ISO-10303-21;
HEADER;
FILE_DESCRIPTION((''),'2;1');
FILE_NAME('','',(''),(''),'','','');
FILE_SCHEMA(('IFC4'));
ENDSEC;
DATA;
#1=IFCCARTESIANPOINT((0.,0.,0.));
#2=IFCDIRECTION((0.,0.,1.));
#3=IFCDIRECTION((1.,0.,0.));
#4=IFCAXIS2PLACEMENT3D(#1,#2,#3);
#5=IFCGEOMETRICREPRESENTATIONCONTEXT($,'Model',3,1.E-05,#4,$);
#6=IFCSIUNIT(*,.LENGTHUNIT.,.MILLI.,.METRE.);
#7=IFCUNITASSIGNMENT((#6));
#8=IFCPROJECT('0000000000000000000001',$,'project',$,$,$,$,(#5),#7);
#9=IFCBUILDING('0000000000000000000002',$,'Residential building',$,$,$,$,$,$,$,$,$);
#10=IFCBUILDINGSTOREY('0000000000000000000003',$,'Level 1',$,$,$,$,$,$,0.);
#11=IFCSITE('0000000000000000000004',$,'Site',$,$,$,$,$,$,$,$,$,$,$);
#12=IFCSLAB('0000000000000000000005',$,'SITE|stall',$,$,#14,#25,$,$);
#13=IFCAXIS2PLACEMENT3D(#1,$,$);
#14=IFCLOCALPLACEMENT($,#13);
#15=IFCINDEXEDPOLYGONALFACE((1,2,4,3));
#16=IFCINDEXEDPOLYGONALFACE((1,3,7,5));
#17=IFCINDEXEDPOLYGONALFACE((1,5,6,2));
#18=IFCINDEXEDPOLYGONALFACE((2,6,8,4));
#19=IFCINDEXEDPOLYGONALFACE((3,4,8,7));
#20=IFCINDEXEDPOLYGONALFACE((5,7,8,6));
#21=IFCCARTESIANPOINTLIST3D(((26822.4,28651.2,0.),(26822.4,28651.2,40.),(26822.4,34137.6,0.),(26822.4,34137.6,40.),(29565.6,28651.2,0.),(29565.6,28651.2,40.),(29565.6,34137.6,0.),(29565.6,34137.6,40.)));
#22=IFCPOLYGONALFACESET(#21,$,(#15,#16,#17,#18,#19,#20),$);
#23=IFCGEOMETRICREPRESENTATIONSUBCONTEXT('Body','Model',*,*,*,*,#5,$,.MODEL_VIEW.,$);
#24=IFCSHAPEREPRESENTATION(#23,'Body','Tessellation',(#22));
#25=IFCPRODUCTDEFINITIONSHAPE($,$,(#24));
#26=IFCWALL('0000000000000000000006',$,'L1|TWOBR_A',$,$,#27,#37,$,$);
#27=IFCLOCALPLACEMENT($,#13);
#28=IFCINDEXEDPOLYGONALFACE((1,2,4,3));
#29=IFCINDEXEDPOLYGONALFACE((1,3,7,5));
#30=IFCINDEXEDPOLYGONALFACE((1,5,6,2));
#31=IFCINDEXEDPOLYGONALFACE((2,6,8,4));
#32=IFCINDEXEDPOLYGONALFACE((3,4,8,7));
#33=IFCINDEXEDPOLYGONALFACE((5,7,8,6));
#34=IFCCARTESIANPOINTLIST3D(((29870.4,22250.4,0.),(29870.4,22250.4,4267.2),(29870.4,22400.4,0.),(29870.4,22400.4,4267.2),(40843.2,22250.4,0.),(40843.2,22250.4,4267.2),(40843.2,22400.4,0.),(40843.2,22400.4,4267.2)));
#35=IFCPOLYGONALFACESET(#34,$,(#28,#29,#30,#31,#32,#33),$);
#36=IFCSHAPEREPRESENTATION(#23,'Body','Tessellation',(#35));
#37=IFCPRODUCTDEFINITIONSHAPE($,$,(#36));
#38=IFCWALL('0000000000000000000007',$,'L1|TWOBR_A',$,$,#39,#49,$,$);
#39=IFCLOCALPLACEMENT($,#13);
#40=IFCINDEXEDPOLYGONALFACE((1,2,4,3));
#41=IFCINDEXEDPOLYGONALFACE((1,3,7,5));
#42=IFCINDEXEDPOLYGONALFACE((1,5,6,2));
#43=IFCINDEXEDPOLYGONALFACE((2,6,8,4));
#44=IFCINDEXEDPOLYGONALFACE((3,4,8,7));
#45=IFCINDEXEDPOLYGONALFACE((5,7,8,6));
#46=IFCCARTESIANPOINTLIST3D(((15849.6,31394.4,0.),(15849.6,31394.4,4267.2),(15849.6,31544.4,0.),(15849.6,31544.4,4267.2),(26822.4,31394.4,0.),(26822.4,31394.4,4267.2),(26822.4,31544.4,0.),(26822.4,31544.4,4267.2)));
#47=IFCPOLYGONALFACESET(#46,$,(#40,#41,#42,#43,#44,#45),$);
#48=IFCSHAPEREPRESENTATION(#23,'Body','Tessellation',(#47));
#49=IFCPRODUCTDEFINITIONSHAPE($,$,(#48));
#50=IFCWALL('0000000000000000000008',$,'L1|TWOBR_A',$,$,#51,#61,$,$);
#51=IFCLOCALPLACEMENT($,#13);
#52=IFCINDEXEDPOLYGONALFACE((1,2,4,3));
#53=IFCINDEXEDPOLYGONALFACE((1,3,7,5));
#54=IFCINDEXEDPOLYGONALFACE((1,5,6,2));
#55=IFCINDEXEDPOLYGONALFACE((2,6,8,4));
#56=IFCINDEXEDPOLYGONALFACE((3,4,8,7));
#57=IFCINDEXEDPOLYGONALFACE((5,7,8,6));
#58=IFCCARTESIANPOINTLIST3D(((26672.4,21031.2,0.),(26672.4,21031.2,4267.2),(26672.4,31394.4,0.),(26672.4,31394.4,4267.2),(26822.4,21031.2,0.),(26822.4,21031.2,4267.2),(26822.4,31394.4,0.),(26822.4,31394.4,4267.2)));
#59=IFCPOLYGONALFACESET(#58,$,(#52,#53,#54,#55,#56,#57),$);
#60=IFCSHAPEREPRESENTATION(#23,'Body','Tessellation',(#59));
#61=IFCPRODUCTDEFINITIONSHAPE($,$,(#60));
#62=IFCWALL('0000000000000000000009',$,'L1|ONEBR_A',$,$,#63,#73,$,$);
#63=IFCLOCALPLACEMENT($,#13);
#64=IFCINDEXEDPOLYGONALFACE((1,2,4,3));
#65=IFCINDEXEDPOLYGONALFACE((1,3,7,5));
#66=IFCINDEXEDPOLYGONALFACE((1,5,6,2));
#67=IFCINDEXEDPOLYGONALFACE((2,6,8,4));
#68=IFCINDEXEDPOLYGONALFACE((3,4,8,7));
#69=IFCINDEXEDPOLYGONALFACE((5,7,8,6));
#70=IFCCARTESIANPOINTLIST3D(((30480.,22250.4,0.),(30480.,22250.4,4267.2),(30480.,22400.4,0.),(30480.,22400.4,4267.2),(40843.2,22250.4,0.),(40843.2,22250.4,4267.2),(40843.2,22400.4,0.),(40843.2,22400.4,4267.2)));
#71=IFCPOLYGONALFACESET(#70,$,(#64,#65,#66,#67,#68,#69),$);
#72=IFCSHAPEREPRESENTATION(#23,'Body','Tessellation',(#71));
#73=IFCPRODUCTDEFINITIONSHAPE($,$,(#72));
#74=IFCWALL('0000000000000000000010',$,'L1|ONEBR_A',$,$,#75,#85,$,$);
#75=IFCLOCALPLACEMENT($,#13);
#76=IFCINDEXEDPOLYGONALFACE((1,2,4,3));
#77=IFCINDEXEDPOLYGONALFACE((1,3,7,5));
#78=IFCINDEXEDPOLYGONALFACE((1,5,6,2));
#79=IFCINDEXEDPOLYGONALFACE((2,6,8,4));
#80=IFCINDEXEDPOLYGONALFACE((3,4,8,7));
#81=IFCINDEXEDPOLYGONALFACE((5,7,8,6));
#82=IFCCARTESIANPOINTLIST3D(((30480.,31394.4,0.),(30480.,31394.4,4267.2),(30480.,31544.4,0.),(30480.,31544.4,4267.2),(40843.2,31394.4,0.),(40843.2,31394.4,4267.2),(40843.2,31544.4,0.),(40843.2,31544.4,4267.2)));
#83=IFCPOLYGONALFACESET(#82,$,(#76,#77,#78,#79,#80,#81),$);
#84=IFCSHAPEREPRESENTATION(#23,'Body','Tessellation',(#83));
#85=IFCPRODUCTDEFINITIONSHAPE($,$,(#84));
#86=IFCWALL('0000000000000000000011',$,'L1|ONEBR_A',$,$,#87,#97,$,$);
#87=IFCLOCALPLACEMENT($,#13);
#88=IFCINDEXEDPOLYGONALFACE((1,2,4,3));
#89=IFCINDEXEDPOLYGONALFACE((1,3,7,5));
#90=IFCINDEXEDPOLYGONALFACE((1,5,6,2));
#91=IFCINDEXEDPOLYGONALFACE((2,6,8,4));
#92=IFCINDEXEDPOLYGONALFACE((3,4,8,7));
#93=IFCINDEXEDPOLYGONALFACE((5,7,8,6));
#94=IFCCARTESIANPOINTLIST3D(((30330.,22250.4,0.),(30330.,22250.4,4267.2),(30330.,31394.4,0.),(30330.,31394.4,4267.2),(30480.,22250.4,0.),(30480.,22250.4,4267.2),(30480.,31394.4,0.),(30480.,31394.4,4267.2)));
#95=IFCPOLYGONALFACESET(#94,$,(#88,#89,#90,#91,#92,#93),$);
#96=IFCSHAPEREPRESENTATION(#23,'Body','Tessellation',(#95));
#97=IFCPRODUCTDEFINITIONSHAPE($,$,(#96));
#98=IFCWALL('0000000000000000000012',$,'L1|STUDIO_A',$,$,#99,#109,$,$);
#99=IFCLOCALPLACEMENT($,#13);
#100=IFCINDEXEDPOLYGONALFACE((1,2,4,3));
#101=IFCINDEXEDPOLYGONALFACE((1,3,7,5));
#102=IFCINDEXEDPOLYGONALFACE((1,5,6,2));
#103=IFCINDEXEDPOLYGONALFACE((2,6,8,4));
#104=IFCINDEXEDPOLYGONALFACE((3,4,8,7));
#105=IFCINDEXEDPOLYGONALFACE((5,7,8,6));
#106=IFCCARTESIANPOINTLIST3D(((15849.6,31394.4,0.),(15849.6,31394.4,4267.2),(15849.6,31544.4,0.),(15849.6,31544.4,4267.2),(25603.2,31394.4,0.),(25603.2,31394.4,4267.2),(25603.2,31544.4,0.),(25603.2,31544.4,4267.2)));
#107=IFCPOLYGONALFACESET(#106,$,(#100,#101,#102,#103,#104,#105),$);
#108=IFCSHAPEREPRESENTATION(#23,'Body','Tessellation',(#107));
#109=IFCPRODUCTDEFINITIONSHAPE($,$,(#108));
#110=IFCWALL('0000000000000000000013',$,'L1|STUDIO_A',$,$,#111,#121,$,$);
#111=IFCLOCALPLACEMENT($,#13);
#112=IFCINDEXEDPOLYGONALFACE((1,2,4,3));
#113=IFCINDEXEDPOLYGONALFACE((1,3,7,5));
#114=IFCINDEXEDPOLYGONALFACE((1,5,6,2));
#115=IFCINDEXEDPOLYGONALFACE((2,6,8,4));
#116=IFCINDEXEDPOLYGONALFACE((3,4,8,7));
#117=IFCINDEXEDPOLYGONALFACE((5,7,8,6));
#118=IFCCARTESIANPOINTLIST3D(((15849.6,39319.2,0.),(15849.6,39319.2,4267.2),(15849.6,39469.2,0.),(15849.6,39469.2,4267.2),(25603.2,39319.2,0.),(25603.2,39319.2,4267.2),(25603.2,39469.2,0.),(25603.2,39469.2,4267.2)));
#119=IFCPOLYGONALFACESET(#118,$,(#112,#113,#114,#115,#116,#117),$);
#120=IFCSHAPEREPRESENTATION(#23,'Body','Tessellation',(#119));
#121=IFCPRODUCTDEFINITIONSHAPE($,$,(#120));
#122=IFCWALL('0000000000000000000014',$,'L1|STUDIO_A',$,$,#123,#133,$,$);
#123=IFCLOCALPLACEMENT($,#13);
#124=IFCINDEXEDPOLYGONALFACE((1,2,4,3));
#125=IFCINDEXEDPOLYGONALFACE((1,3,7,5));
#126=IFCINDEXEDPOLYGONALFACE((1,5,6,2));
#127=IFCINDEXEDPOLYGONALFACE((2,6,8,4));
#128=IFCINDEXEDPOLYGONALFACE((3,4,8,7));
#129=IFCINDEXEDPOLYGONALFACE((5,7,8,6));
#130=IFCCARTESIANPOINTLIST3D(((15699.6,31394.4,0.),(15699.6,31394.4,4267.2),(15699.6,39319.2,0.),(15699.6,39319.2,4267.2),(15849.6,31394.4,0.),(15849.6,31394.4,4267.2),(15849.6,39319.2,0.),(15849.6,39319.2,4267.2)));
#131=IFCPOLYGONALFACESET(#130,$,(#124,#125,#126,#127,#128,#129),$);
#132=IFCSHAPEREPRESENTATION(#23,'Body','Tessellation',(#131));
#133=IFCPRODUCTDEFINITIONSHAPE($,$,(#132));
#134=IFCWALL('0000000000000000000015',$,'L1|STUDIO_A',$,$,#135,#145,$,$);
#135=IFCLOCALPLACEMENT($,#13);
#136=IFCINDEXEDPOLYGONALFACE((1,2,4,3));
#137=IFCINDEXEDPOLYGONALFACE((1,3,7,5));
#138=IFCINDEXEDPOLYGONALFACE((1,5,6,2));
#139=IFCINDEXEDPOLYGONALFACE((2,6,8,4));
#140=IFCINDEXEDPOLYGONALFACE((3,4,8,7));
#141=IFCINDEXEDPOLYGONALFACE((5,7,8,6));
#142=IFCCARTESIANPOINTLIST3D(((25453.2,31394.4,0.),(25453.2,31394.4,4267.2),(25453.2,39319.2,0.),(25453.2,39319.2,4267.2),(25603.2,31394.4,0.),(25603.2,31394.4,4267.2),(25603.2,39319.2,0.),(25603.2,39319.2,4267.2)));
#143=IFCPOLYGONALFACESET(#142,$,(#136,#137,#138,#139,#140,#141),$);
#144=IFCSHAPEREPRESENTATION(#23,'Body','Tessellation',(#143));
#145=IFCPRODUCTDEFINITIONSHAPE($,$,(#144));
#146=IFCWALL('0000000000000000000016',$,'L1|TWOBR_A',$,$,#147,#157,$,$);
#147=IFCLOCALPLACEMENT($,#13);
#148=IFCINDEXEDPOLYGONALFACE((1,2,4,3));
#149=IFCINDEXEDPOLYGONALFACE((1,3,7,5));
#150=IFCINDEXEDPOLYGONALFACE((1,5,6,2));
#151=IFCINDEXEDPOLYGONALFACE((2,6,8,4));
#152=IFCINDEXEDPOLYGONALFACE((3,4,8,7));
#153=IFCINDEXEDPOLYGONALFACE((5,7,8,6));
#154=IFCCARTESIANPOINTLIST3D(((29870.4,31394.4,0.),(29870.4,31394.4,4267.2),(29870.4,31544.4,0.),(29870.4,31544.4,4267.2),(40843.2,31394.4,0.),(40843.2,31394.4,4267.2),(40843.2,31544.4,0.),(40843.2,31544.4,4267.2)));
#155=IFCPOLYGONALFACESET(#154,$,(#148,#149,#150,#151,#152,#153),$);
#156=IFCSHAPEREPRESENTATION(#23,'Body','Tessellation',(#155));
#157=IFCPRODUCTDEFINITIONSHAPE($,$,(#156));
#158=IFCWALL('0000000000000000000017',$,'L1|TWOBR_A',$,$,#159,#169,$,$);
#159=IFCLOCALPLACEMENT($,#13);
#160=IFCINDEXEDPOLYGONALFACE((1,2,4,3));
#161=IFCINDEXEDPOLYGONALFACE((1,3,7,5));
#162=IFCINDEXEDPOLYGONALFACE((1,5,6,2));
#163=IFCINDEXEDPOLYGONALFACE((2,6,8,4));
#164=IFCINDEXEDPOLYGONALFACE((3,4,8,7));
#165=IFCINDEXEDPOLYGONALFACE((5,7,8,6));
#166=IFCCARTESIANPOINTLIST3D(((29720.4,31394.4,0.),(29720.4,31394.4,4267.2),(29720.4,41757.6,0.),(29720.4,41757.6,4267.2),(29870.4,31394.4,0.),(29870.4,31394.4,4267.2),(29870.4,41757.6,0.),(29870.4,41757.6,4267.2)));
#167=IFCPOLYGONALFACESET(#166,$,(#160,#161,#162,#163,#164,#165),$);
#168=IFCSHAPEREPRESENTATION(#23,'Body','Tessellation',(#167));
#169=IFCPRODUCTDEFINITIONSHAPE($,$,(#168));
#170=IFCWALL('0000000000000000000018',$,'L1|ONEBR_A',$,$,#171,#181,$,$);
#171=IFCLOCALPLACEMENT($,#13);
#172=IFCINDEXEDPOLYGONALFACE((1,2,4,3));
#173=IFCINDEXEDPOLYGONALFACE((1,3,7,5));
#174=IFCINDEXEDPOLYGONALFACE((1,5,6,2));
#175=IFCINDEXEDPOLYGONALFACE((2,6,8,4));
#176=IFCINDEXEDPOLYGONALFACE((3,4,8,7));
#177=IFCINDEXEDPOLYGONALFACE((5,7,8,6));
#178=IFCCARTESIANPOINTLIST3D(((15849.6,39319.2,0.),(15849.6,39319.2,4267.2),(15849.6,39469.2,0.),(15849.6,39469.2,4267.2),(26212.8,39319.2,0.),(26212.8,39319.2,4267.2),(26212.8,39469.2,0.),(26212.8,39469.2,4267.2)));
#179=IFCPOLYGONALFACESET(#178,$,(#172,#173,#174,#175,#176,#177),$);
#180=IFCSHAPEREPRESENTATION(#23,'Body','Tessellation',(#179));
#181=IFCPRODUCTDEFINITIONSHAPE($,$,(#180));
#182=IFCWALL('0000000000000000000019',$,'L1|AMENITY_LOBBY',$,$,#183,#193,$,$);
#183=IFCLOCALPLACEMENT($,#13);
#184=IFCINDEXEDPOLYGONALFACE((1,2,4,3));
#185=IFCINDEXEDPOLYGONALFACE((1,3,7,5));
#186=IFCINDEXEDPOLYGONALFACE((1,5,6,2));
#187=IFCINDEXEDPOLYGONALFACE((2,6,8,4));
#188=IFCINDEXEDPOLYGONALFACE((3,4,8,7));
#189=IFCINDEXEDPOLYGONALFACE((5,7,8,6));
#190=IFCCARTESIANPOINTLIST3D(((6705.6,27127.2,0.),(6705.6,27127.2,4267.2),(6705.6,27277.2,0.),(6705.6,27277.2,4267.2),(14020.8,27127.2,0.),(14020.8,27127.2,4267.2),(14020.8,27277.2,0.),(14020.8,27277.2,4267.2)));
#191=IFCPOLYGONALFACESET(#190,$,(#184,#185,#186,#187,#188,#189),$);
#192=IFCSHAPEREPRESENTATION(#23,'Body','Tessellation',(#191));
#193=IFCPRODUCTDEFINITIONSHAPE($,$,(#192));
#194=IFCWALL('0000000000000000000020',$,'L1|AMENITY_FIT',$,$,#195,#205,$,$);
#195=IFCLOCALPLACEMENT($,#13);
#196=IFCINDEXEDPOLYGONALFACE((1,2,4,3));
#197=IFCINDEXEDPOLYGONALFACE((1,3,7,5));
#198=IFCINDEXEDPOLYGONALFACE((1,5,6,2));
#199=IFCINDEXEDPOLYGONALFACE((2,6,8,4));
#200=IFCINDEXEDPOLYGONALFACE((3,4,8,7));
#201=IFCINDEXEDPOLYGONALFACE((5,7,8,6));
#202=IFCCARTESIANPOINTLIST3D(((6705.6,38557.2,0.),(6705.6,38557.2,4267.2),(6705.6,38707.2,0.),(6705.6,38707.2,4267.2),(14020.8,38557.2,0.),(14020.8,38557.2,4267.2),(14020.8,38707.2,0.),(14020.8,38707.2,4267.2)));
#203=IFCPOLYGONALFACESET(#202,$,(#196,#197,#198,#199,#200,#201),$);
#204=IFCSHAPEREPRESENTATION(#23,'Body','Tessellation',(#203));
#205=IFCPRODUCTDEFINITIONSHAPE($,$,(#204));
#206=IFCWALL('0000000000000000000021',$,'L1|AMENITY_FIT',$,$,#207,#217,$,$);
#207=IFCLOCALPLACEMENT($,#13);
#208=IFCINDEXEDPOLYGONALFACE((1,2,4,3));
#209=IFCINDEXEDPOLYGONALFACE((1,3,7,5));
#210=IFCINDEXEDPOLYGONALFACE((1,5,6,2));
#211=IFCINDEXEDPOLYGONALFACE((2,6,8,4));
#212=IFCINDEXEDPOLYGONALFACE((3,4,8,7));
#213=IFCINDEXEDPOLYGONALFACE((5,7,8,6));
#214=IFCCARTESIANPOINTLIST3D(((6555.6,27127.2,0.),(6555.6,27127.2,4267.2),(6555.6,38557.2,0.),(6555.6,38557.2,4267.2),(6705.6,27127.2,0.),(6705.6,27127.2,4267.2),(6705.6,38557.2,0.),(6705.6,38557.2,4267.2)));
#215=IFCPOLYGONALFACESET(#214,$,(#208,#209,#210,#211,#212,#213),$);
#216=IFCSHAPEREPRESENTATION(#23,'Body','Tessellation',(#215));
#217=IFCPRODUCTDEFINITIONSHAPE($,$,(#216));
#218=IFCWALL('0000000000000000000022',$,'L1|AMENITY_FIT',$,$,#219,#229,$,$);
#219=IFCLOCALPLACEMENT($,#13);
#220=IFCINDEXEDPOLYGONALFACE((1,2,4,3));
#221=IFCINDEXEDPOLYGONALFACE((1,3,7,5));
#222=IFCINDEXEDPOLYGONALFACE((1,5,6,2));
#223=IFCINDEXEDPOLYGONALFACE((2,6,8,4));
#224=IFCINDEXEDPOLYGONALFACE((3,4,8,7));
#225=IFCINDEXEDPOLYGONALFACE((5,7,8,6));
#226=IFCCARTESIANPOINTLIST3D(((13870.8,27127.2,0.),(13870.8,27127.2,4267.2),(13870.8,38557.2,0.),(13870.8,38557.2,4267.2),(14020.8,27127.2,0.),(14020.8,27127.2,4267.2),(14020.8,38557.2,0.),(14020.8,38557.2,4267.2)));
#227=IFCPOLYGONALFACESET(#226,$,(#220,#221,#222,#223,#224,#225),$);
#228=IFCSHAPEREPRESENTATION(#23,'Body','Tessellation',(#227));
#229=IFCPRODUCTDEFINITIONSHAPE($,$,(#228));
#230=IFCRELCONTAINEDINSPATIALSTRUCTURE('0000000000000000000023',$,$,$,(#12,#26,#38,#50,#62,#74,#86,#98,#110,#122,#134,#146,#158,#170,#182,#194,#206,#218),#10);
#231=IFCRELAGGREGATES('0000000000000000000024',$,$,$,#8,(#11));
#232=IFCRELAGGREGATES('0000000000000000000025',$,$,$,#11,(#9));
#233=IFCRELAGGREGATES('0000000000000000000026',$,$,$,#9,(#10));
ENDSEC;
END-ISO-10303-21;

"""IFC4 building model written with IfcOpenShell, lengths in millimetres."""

from ifc_helpers import new_model, si_unit, frame, origin_with_axes, place, context, subcontext, project, spatial, indexed_curve, outline, extrude, element, save


model = new_model("IFC4")

# Units and contexts
model_context = context("Model", 3, precision=1e-05, world=origin_with_axes())
body_context = subcontext(model_context, "Body", "Model", "MODEL_VIEW")
ifc_project = project(units=[si_unit("LENGTHUNIT", "METRE", prefix="MILLI")], contexts=[model_context])

# Site, building, storey
site = spatial("IfcSite", under=ifc_project, Name="Site")
building = spatial("IfcBuilding", under=site, Name="Residential building")
storey = spatial("IfcBuildingStorey", under=building, Name="Level 1", Elevation=0.0)

# Slab
slab_placement = place(None, frame((26822.4, 28651.2, 0.0), z_axis=(0.0, 0.0, 1.0), x_axis=(1.0, 0.0, 0.0)))
element("IfcSlab", 1, at=slab_placement, inside=storey, Name="SITE|stall", context=body_context, shape_type="SweptSolid", body=[
    extrude(outline(indexed_curve([(0.0, 0.0), (2743.2, 0.0), (2743.2, 5486.4), (0.0, 5486.4), (0.0, 0.0)])), None, (0.0, 0.0, 1.0), 40.0),
])

# Walls
for number, where, z_axis, x_axis, name in (
    (2, (29870.4, 22250.4, 0.0), (0.0, 0.0, 1.0), (1.0, 0.0, 0.0), "L1|TWOBR_A"),
    (3, (15849.6, 31394.4, 0.0), (0.0, 0.0, 1.0), (1.0, 0.0, 0.0), "L1|TWOBR_A"),
):
    element("IfcWall", number, at=place(None, frame(where, z_axis=z_axis, x_axis=x_axis)), inside=storey, Name=name, context=body_context, shape_type="SweptSolid", body=[
        extrude(outline(indexed_curve([(0.0, 0.0), (0.0, 150.0), (10972.8, 150.0), (10972.8, 0.0), (0.0, 0.0)], self_intersect=False)), origin_with_axes(), (0.0, 0.0, 1.0), 4267.2),
    ])
for number, where, z_axis, x_axis, name in (
    (4, (26822.4, 21031.2, 0.0), (0.0, 0.0, 1.0), (0.0, 1.0, 0.0), "L1|TWOBR_A"),
    (5, (30480.0, 22250.4, 0.0), (0.0, 0.0, 1.0), (1.0, 0.0, 0.0), "L1|ONEBR_A"),
    (6, (30480.0, 31394.4, 0.0), (0.0, 0.0, 1.0), (1.0, 0.0, 0.0), "L1|ONEBR_A"),
):
    element("IfcWall", number, at=place(None, frame(where, z_axis=z_axis, x_axis=x_axis)), inside=storey, Name=name, context=body_context, shape_type="SweptSolid", body=[
        extrude(outline(indexed_curve([(0.0, 0.0), (0.0, 150.0), (10363.2, 150.0), (10363.2, 0.0), (0.0, 0.0)], self_intersect=False)), origin_with_axes(), (0.0, 0.0, 1.0), 4267.2),
    ])
wall_1_placement = place(None, frame((30480.0, 22250.4, 0.0), z_axis=(0.0, 0.0, 1.0), x_axis=(0.0, 1.0, 0.0)))
element("IfcWall", 7, at=wall_1_placement, inside=storey, Name="L1|ONEBR_A", context=body_context, shape_type="SweptSolid", body=[
    extrude(outline(indexed_curve([(0.0, 0.0), (0.0, 150.0), (9144.0, 150.0), (9144.0, 0.0), (0.0, 0.0)], self_intersect=False)), origin_with_axes(), (0.0, 0.0, 1.0), 4267.2),
])
for number, where, z_axis, x_axis, name in (
    (8, (15849.6, 31394.4, 0.0), (0.0, 0.0, 1.0), (1.0, 0.0, 0.0), "L1|STUDIO_A"),
    (9, (15849.6, 39319.2, 0.0), (0.0, 0.0, 1.0), (1.0, 0.0, 0.0), "L1|STUDIO_A"),
):
    element("IfcWall", number, at=place(None, frame(where, z_axis=z_axis, x_axis=x_axis)), inside=storey, Name=name, context=body_context, shape_type="SweptSolid", body=[
        extrude(outline(indexed_curve([(0.0, 0.0), (0.0, 150.0), (9753.6, 150.0), (9753.6, 0.0), (0.0, 0.0)], self_intersect=False)), origin_with_axes(), (0.0, 0.0, 1.0), 4267.2),
    ])
for number, where, z_axis, x_axis, name in (
    (10, (15849.6, 31394.4, 0.0), (0.0, 0.0, 1.0), (0.0, 1.0, 0.0), "L1|STUDIO_A"),
    (11, (25603.2, 31394.4, 0.0), (0.0, 0.0, 1.0), (0.0, 1.0, 0.0), "L1|STUDIO_A"),
):
    element("IfcWall", number, at=place(None, frame(where, z_axis=z_axis, x_axis=x_axis)), inside=storey, Name=name, context=body_context, shape_type="SweptSolid", body=[
        extrude(outline(indexed_curve([(0.0, 0.0), (0.0, 150.0), (7924.8, 150.0), (7924.8, 0.0), (0.0, 0.0)], self_intersect=False)), origin_with_axes(), (0.0, 0.0, 1.0), 4267.2),
    ])
wall_2_placement = place(None, frame((29870.4, 31394.4, 0.0), z_axis=(0.0, 0.0, 1.0), x_axis=(1.0, 0.0, 0.0)))
element("IfcWall", 12, at=wall_2_placement, inside=storey, Name="L1|TWOBR_A", context=body_context, shape_type="SweptSolid", body=[
    extrude(outline(indexed_curve([(0.0, 0.0), (0.0, 150.0), (10972.8, 150.0), (10972.8, 0.0), (0.0, 0.0)], self_intersect=False)), origin_with_axes(), (0.0, 0.0, 1.0), 4267.2),
])
for number, where, z_axis, x_axis, name in (
    (13, (29870.4, 31394.4, 0.0), (0.0, 0.0, 1.0), (0.0, 1.0, 0.0), "L1|TWOBR_A"),
    (14, (15849.6, 39319.2, 0.0), (0.0, 0.0, 1.0), (1.0, 0.0, 0.0), "L1|ONEBR_A"),
):
    element("IfcWall", number, at=place(None, frame(where, z_axis=z_axis, x_axis=x_axis)), inside=storey, Name=name, context=body_context, shape_type="SweptSolid", body=[
        extrude(outline(indexed_curve([(0.0, 0.0), (0.0, 150.0), (10363.2, 150.0), (10363.2, 0.0), (0.0, 0.0)], self_intersect=False)), origin_with_axes(), (0.0, 0.0, 1.0), 4267.2),
    ])
for number, where, z_axis, x_axis, name in (
    (15, (6705.6, 27127.2, 0.0), (0.0, 0.0, 1.0), (1.0, 0.0, 0.0), "L1|AMENITY_LOBBY"),
    (16, (6705.6, 38557.2, 0.0), (0.0, 0.0, 1.0), (1.0, 0.0, 0.0), "L1|AMENITY_FIT"),
):
    element("IfcWall", number, at=place(None, frame(where, z_axis=z_axis, x_axis=x_axis)), inside=storey, Name=name, context=body_context, shape_type="SweptSolid", body=[
        extrude(outline(indexed_curve([(0.0, 0.0), (0.0, 150.0), (7315.2, 150.0), (7315.2, 0.0), (0.0, 0.0)], self_intersect=False)), origin_with_axes(), (0.0, 0.0, 1.0), 4267.2),
    ])
for number, where, z_axis, x_axis, name in (
    (17, (6705.6, 27127.2, 0.0), (0.0, 0.0, 1.0), (0.0, 1.0, 0.0), "L1|AMENITY_FIT"),
    (18, (14020.8, 27127.2, 0.0), (0.0, 0.0, 1.0), (0.0, 1.0, 0.0), "L1|AMENITY_FIT"),
):
    element("IfcWall", number, at=place(None, frame(where, z_axis=z_axis, x_axis=x_axis)), inside=storey, Name=name, context=body_context, shape_type="SweptSolid", body=[
        extrude(outline(indexed_curve([(0.0, 0.0), (0.0, 150.0), (11430.0, 150.0), (11430.0, 0.0), (0.0, 0.0)], self_intersect=False)), origin_with_axes(), (0.0, 0.0, 1.0), 4267.2),
    ])

save(model, "model.ifc")
